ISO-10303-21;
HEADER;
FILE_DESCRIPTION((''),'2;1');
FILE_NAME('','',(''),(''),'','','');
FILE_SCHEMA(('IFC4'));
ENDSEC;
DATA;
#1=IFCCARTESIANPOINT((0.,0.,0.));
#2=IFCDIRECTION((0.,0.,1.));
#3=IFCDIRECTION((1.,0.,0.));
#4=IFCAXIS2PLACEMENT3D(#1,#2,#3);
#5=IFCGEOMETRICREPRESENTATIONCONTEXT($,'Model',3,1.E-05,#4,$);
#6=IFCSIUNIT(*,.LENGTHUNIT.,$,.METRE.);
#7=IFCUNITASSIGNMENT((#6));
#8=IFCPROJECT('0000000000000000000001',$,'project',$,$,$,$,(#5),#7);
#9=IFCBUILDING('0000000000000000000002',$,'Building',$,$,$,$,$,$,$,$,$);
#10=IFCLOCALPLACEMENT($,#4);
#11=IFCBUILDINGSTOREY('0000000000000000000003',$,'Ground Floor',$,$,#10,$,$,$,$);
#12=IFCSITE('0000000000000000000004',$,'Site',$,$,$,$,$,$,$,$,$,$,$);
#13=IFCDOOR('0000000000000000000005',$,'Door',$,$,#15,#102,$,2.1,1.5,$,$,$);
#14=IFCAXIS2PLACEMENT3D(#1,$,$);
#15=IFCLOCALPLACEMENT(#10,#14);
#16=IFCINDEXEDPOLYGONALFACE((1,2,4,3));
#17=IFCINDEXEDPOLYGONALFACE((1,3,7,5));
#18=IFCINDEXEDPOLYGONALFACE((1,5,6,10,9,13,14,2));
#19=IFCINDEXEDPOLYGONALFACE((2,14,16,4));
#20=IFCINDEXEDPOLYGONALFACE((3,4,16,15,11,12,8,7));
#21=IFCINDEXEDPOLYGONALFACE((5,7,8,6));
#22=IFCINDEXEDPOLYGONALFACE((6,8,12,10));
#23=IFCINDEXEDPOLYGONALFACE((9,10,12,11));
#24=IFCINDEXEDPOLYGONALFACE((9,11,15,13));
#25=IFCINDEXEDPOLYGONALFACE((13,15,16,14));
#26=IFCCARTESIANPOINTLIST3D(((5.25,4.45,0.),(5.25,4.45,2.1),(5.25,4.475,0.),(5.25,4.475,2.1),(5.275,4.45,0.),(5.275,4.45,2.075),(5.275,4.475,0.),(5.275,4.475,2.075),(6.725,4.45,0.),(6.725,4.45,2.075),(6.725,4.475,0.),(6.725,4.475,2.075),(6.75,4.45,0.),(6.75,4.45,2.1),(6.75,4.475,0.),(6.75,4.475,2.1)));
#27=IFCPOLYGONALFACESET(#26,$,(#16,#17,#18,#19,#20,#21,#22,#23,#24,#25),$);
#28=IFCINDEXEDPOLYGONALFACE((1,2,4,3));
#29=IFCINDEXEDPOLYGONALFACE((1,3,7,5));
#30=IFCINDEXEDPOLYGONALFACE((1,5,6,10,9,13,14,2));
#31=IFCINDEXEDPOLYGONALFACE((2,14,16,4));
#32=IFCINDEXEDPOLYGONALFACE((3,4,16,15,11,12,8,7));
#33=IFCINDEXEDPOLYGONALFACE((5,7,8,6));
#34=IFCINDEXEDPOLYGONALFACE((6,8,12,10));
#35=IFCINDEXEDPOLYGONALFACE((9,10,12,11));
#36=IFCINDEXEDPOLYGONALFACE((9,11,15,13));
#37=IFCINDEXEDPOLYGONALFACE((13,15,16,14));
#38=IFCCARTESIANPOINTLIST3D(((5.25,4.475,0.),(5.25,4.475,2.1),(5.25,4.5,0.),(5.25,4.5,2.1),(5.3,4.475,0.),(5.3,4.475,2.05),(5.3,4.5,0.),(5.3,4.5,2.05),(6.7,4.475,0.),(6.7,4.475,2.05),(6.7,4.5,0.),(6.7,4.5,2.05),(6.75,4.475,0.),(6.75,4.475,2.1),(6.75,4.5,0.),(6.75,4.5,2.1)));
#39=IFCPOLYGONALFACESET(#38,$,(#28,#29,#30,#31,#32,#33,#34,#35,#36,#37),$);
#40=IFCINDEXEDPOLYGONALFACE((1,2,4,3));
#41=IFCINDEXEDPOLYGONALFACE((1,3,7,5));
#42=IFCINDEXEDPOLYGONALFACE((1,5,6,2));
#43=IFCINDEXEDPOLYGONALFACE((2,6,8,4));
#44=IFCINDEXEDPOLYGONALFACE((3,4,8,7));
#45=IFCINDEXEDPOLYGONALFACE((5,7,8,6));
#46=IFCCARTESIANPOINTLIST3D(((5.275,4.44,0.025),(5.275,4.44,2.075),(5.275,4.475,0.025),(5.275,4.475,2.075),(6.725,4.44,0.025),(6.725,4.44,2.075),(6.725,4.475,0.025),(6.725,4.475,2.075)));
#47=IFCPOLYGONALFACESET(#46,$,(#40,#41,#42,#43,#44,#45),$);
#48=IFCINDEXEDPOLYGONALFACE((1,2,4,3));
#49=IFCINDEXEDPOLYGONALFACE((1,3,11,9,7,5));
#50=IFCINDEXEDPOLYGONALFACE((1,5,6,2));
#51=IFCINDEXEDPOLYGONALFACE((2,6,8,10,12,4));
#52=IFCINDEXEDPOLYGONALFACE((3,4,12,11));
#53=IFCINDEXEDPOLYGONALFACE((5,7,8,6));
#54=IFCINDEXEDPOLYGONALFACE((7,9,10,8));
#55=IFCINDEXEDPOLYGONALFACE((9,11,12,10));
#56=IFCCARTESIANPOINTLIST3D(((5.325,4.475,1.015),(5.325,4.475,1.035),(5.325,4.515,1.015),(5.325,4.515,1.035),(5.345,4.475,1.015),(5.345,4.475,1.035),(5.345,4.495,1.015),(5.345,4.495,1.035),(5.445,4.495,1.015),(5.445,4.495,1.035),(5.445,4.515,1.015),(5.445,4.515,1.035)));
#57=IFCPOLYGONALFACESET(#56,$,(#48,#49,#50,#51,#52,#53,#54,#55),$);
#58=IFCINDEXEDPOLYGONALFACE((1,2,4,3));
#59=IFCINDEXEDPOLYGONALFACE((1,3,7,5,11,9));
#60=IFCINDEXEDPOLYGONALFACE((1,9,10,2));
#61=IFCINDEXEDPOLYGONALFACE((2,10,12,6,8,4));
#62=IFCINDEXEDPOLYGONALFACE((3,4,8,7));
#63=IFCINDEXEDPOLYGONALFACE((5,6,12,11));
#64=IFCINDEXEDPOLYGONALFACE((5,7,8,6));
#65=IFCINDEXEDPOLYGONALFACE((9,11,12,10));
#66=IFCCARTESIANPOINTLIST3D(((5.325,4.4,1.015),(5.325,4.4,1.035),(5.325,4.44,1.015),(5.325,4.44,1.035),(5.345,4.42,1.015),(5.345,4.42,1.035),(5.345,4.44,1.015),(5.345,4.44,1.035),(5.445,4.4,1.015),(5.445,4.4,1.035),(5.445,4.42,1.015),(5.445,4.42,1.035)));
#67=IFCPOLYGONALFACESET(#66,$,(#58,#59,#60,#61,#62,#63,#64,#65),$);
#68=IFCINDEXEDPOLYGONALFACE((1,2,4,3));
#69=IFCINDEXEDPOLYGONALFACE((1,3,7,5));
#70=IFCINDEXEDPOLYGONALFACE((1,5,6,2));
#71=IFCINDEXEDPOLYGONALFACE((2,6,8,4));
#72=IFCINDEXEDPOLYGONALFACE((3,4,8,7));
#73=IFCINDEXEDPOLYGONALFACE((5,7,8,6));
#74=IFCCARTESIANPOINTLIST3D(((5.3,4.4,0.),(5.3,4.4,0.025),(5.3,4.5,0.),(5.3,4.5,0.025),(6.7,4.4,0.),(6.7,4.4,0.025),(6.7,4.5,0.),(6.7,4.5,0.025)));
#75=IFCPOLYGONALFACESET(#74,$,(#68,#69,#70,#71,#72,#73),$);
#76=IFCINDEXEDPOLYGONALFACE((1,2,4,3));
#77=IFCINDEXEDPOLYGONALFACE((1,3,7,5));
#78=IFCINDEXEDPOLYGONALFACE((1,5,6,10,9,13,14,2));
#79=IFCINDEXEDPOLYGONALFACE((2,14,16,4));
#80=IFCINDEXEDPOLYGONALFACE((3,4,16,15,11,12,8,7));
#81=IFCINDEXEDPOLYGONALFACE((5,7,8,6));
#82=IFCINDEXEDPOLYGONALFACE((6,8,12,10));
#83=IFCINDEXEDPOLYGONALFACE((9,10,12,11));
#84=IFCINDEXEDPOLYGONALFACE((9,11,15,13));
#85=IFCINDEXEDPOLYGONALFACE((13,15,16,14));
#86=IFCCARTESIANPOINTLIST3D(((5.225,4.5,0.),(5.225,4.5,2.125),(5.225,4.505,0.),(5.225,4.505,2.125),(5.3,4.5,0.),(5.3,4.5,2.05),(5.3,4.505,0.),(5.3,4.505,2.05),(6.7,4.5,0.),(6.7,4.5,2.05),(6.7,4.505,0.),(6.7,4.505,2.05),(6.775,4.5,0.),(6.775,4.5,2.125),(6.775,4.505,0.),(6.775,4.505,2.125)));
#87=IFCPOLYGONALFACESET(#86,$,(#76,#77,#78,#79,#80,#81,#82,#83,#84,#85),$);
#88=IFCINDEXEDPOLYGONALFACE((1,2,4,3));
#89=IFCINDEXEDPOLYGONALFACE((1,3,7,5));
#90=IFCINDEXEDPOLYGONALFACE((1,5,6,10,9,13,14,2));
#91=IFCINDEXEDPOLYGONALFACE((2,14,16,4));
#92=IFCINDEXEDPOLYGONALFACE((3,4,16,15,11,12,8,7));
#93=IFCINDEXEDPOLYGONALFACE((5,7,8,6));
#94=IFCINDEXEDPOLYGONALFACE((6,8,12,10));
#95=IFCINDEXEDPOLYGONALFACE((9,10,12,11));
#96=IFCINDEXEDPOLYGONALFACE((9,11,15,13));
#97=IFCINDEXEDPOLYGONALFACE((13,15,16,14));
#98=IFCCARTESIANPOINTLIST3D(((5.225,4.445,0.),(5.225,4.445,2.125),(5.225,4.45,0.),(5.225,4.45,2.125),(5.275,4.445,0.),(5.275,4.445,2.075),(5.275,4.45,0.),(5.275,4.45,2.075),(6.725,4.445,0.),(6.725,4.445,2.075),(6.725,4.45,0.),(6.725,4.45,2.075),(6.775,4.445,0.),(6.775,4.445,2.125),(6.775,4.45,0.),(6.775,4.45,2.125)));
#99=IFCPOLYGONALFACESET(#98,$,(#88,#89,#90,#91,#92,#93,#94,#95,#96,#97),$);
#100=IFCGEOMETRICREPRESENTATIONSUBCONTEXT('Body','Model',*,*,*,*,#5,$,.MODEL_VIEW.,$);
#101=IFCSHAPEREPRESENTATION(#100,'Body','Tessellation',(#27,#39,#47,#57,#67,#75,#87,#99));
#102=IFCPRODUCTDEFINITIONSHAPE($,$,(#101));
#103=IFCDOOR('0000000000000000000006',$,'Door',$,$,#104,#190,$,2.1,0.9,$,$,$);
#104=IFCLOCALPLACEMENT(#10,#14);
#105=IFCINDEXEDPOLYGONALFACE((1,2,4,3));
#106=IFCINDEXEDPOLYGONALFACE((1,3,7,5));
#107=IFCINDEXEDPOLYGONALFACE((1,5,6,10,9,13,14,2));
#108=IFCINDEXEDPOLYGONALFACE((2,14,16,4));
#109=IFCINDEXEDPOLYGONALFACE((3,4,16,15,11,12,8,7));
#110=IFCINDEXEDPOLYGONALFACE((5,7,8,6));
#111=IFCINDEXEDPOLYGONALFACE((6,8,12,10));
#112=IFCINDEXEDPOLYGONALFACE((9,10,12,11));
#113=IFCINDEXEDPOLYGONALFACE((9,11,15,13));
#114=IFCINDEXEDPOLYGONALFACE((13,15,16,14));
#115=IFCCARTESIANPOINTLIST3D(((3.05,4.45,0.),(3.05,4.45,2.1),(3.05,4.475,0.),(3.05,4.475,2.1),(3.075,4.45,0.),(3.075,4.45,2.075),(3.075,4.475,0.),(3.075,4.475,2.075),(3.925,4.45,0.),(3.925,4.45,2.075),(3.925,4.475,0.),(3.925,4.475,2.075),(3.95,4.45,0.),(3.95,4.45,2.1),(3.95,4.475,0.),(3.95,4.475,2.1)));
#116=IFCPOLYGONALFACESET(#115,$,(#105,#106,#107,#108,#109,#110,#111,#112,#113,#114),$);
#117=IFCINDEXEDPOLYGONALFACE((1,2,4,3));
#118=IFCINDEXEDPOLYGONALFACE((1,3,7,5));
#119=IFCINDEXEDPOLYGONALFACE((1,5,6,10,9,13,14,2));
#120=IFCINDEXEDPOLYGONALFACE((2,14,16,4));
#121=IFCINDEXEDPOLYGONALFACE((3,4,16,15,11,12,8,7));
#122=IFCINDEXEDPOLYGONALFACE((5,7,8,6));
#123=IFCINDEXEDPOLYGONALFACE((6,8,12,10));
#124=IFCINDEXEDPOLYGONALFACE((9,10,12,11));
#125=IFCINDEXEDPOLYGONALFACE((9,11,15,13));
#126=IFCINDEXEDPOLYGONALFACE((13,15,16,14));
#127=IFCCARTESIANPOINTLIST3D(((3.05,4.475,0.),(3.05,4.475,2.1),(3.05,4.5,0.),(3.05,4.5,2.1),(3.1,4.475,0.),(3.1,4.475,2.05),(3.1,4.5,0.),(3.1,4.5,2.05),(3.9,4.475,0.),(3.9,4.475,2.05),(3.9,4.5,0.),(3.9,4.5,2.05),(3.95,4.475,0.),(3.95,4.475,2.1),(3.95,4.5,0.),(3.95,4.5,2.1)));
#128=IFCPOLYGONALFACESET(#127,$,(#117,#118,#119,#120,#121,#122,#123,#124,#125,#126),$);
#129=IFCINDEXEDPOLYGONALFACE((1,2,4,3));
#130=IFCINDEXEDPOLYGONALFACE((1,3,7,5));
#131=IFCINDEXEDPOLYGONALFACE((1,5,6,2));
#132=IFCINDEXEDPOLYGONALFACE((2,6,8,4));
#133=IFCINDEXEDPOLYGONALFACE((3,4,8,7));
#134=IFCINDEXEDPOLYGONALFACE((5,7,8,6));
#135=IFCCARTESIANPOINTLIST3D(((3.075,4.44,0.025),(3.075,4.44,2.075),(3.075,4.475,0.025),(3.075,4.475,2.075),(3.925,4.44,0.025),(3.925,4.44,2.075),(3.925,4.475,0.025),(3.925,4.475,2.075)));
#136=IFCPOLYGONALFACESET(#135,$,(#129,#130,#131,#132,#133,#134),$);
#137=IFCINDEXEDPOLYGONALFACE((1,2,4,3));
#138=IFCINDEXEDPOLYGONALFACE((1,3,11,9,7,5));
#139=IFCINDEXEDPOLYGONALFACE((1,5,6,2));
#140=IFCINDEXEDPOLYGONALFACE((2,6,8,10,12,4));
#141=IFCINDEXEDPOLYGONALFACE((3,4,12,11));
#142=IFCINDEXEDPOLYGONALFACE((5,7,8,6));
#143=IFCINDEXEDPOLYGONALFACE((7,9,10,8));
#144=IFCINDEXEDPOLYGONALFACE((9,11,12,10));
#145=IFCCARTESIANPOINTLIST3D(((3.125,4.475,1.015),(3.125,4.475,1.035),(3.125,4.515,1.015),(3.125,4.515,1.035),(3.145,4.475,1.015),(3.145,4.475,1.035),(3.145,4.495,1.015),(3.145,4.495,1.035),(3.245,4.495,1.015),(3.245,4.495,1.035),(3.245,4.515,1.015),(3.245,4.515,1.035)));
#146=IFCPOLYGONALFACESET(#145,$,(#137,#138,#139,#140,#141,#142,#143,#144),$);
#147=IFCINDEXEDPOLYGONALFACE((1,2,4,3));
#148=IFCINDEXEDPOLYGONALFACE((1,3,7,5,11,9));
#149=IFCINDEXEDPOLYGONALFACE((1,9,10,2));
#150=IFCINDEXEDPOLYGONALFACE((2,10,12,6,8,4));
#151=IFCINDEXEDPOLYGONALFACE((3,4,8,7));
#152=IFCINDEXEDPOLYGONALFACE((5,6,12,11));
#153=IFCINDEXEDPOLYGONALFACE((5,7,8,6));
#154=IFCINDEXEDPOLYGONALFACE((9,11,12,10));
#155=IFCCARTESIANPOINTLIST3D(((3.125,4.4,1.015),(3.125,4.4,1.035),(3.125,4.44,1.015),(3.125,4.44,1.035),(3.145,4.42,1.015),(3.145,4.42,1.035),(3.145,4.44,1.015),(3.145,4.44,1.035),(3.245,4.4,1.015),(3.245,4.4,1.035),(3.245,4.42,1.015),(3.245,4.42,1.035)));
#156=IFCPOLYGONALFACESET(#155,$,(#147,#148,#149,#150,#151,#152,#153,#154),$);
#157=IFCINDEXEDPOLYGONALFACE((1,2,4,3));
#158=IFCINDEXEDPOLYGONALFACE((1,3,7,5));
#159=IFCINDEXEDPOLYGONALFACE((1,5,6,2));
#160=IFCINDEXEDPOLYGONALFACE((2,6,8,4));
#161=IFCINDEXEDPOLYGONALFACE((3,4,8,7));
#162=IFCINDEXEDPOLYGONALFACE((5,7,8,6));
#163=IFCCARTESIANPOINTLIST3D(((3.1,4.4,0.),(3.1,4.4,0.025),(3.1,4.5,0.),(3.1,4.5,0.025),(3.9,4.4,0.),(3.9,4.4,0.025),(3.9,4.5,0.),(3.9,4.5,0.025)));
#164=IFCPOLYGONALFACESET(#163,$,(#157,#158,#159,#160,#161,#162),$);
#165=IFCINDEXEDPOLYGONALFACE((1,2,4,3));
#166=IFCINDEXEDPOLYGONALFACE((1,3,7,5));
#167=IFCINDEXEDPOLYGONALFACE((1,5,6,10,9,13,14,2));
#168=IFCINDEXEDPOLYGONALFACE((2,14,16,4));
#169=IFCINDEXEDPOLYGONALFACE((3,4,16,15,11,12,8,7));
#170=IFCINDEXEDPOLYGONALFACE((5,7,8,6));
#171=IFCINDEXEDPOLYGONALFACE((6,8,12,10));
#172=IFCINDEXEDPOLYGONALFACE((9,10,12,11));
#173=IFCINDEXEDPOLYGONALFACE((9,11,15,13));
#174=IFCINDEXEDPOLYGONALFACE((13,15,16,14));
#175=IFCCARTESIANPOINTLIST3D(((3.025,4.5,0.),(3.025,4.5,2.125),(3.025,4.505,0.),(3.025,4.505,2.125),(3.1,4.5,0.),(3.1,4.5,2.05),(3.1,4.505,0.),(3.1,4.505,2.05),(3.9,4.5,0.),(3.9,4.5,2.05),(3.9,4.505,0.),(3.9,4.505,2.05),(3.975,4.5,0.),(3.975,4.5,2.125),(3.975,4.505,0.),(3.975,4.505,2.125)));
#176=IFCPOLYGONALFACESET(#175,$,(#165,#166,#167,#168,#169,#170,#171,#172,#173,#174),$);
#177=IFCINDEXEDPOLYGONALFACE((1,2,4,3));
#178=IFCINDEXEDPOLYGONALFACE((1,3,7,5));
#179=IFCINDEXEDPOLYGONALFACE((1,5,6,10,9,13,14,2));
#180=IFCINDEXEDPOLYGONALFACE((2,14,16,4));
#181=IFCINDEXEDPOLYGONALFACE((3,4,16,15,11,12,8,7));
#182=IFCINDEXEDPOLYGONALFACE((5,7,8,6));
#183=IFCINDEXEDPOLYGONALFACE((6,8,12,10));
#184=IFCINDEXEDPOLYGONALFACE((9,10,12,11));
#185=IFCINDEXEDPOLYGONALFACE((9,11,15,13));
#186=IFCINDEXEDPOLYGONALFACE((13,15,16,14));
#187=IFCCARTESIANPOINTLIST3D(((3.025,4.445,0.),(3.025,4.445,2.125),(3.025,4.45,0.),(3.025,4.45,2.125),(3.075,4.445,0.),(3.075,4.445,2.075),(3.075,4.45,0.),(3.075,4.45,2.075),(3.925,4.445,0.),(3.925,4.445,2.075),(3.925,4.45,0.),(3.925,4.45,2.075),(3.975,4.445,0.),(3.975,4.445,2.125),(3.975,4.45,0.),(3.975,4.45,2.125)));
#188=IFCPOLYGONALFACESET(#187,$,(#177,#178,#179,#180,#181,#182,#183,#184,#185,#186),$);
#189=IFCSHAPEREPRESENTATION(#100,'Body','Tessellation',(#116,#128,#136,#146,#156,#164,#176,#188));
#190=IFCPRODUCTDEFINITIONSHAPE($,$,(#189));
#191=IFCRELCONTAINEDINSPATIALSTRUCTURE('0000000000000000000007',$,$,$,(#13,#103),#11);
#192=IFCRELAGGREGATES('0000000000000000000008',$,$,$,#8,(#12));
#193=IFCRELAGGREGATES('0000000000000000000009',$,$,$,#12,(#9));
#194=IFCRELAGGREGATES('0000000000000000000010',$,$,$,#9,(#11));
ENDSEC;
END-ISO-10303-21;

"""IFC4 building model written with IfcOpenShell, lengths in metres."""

from ifc_helpers import new_model, si_unit, frame, origin_with_axes, place, context, subcontext, project, spatial, line, indexed_curve, outline, extrude, element, save


model = new_model("IFC4")

# Units and contexts
model_context = context("Model", 3, precision=1e-05, world=origin_with_axes())
body_context = subcontext(model_context, "Body", "Model", "MODEL_VIEW")
ifc_project = project(units=[si_unit("LENGTHUNIT", "METRE")], contexts=[model_context])

# Site, building, storey
site = spatial("IfcSite", under=ifc_project, Name="Site")
building = spatial("IfcBuilding", under=site, Name="Building")
storey_placement = place(None, origin_with_axes())
storey = spatial("IfcBuildingStorey", under=building, at=storey_placement, Name="Ground Floor")

# Doors
door_1_placement = place(storey_placement, frame((6.75, 4.5, 0.0), z_axis=(0.0, 0.0, 1.0), x_axis=(-1.0, 0.0, 0.0)))
element("IfcDoor", 1, at=door_1_placement, inside=storey, Name="Door", OverallHeight=2.1, OverallWidth=1.5, context=body_context, shape_type="SweptSolid", body=[
    extrude(outline(indexed_curve([(0.0, 0.0), (0.0, 2.1), (1.5, 2.1), (1.5, 0.0), (1.475, 0.0), (1.475, 2.075), (0.025, 2.075), (0.025, 0.0)], segments=[line(1, 2, 3, 4, 5, 6, 7, 8, 1)])), frame((0.0, 0.025, 0.0), z_axis=(0.0, -1.0, 0.0), x_axis=(1.0, 0.0, 0.0)), (0.0, 0.0, -1.0), 0.025),
    extrude(outline(indexed_curve([(0.0, 0.0), (0.0, 2.1), (1.5, 2.1), (1.5, 0.0), (1.45, 0.0), (1.45, 2.05), (0.05, 2.05), (0.05, 0.0)], segments=[line(1, 2, 3, 4, 5, 6, 7, 8, 1)])), frame((0.0, 0.0, 0.0), z_axis=(0.0, -1.0, 0.0), x_axis=(1.0, 0.0, 0.0)), (0.0, 0.0, -1.0), 0.025),
    extrude(outline(indexed_curve([(0.0, 0.0), (1.45, 0.0), (1.45, 0.035), (0.0, 0.035)], segments=[line(1, 2, 3, 4, 1)])), frame((0.025, 0.025, 0.025), z_axis=(0.0, 0.0, 1.0), x_axis=(1.0, 0.0, 0.0)), (0.0, 0.0, 1.0), 2.05),
    extrude(outline(indexed_curve([(0.0, 0.0), (0.0, -0.04), (-0.12, -0.04), (-0.12, -0.02), (-0.02, -0.02), (-0.02, 0.0)], segments=[line(1, 2, 3, 4, 5, 6, 1)])), frame((1.425, 0.025, 1.015), z_axis=(0.0, 0.0, 1.0), x_axis=(1.0, 0.0, 0.0)), (0.0, 0.0, 1.0), 0.02),
    extrude(outline(indexed_curve([(0.0, 0.0), (0.0, 0.04), (-0.12, 0.04), (-0.12, 0.02), (-0.02, 0.02), (-0.02, 0.0)], segments=[line(1, 2, 3, 4, 5, 6, 1)])), frame((1.425, 0.06, 1.015), z_axis=(0.0, 0.0, 1.0), x_axis=(1.0, 0.0, 0.0)), (0.0, 0.0, 1.0), 0.02),
    extrude(outline(indexed_curve([(0.0, 0.0), (1.4, 0.0), (1.4, 0.1), (0.0, 0.1)], segments=[line(1, 2, 3, 4, 1)])), frame((0.05, 0.0, 0.0), z_axis=(0.0, 0.0, 1.0), x_axis=(1.0, 0.0, 0.0)), (0.0, 0.0, 1.0), 0.025),
    extrude(outline(indexed_curve([(0.0, 0.0), (0.0, 2.125), (1.55, 2.125), (1.55, 0.0), (1.475, 0.0), (1.475, 2.05), (0.075, 2.05), (0.075, 0.0)], segments=[line(1, 2, 3, 4, 5, 6, 7, 8, 1)])), frame((-0.025, -0.005, 0.0), z_axis=(0.0, -1.0, 0.0), x_axis=(1.0, 0.0, 0.0)), (0.0, 0.0, -1.0), 0.005),
    extrude(outline(indexed_curve([(0.0, 0.0), (0.0, 2.125), (1.55, 2.125), (1.55, 0.0), (1.5, 0.0), (1.5, 2.075), (0.05, 2.075), (0.05, 0.0)], segments=[line(1, 2, 3, 4, 5, 6, 7, 8, 1)])), frame((-0.025, 0.05, 0.0), z_axis=(0.0, -1.0, 0.0), x_axis=(1.0, 0.0, 0.0)), (0.0, 0.0, -1.0), 0.005),
])
door_2_placement = place(storey_placement, frame((3.95, 4.5, 0.0), z_axis=(0.0, 0.0, 1.0), x_axis=(-1.0, 0.0, 0.0)))
element("IfcDoor", 2, at=door_2_placement, inside=storey, Name="Door", OverallHeight=2.1, OverallWidth=0.9, context=body_context, shape_type="SweptSolid", body=[
    extrude(outline(indexed_curve([(0.0, 0.0), (0.0, 2.1), (0.9, 2.1), (0.9, 0.0), (0.875, 0.0), (0.875, 2.075), (0.025, 2.075), (0.025, 0.0)], segments=[line(1, 2, 3, 4, 5, 6, 7, 8, 1)])), frame((0.0, 0.025, 0.0), z_axis=(0.0, -1.0, 0.0), x_axis=(1.0, 0.0, 0.0)), (0.0, 0.0, -1.0), 0.025),
    extrude(outline(indexed_curve([(0.0, 0.0), (0.0, 2.1), (0.9, 2.1), (0.9, 0.0), (0.85, 0.0), (0.85, 2.05), (0.05, 2.05), (0.05, 0.0)], segments=[line(1, 2, 3, 4, 5, 6, 7, 8, 1)])), frame((0.0, 0.0, 0.0), z_axis=(0.0, -1.0, 0.0), x_axis=(1.0, 0.0, 0.0)), (0.0, 0.0, -1.0), 0.025),
    extrude(outline(indexed_curve([(0.0, 0.0), (0.85, 0.0), (0.85, 0.035), (0.0, 0.035)], segments=[line(1, 2, 3, 4, 1)])), frame((0.025, 0.025, 0.025), z_axis=(0.0, 0.0, 1.0), x_axis=(1.0, 0.0, 0.0)), (0.0, 0.0, 1.0), 2.05),
    extrude(outline(indexed_curve([(0.0, 0.0), (0.0, -0.04), (-0.12, -0.04), (-0.12, -0.02), (-0.02, -0.02), (-0.02, 0.0)], segments=[line(1, 2, 3, 4, 5, 6, 1)])), frame((0.825, 0.025, 1.015), z_axis=(0.0, 0.0, 1.0), x_axis=(1.0, 0.0, 0.0)), (0.0, 0.0, 1.0), 0.02),
    extrude(outline(indexed_curve([(0.0, 0.0), (0.0, 0.04), (-0.12, 0.04), (-0.12, 0.02), (-0.02, 0.02), (-0.02, 0.0)], segments=[line(1, 2, 3, 4, 5, 6, 1)])), frame((0.825, 0.06, 1.015), z_axis=(0.0, 0.0, 1.0), x_axis=(1.0, 0.0, 0.0)), (0.0, 0.0, 1.0), 0.02),
    extrude(outline(indexed_curve([(0.0, 0.0), (0.8, 0.0), (0.8, 0.1), (0.0, 0.1)], segments=[line(1, 2, 3, 4, 1)])), frame((0.05, 0.0, 0.0), z_axis=(0.0, 0.0, 1.0), x_axis=(1.0, 0.0, 0.0)), (0.0, 0.0, 1.0), 0.025),
    extrude(outline(indexed_curve([(0.0, 0.0), (0.0, 2.125), (0.95, 2.125), (0.95, 0.0), (0.875, 0.0), (0.875, 2.05), (0.075, 2.05), (0.075, 0.0)], segments=[line(1, 2, 3, 4, 5, 6, 7, 8, 1)])), frame((-0.025, -0.005, 0.0), z_axis=(0.0, -1.0, 0.0), x_axis=(1.0, 0.0, 0.0)), (0.0, 0.0, -1.0), 0.005),
    extrude(outline(indexed_curve([(0.0, 0.0), (0.0, 2.125), (0.95, 2.125), (0.95, 0.0), (0.9, 0.0), (0.9, 2.075), (0.05, 2.075), (0.05, 0.0)], segments=[line(1, 2, 3, 4, 5, 6, 7, 8, 1)])), frame((-0.025, 0.05, 0.0), z_axis=(0.0, -1.0, 0.0), x_axis=(1.0, 0.0, 0.0)), (0.0, 0.0, -1.0), 0.005),
])

save(model, "model.ifc")
